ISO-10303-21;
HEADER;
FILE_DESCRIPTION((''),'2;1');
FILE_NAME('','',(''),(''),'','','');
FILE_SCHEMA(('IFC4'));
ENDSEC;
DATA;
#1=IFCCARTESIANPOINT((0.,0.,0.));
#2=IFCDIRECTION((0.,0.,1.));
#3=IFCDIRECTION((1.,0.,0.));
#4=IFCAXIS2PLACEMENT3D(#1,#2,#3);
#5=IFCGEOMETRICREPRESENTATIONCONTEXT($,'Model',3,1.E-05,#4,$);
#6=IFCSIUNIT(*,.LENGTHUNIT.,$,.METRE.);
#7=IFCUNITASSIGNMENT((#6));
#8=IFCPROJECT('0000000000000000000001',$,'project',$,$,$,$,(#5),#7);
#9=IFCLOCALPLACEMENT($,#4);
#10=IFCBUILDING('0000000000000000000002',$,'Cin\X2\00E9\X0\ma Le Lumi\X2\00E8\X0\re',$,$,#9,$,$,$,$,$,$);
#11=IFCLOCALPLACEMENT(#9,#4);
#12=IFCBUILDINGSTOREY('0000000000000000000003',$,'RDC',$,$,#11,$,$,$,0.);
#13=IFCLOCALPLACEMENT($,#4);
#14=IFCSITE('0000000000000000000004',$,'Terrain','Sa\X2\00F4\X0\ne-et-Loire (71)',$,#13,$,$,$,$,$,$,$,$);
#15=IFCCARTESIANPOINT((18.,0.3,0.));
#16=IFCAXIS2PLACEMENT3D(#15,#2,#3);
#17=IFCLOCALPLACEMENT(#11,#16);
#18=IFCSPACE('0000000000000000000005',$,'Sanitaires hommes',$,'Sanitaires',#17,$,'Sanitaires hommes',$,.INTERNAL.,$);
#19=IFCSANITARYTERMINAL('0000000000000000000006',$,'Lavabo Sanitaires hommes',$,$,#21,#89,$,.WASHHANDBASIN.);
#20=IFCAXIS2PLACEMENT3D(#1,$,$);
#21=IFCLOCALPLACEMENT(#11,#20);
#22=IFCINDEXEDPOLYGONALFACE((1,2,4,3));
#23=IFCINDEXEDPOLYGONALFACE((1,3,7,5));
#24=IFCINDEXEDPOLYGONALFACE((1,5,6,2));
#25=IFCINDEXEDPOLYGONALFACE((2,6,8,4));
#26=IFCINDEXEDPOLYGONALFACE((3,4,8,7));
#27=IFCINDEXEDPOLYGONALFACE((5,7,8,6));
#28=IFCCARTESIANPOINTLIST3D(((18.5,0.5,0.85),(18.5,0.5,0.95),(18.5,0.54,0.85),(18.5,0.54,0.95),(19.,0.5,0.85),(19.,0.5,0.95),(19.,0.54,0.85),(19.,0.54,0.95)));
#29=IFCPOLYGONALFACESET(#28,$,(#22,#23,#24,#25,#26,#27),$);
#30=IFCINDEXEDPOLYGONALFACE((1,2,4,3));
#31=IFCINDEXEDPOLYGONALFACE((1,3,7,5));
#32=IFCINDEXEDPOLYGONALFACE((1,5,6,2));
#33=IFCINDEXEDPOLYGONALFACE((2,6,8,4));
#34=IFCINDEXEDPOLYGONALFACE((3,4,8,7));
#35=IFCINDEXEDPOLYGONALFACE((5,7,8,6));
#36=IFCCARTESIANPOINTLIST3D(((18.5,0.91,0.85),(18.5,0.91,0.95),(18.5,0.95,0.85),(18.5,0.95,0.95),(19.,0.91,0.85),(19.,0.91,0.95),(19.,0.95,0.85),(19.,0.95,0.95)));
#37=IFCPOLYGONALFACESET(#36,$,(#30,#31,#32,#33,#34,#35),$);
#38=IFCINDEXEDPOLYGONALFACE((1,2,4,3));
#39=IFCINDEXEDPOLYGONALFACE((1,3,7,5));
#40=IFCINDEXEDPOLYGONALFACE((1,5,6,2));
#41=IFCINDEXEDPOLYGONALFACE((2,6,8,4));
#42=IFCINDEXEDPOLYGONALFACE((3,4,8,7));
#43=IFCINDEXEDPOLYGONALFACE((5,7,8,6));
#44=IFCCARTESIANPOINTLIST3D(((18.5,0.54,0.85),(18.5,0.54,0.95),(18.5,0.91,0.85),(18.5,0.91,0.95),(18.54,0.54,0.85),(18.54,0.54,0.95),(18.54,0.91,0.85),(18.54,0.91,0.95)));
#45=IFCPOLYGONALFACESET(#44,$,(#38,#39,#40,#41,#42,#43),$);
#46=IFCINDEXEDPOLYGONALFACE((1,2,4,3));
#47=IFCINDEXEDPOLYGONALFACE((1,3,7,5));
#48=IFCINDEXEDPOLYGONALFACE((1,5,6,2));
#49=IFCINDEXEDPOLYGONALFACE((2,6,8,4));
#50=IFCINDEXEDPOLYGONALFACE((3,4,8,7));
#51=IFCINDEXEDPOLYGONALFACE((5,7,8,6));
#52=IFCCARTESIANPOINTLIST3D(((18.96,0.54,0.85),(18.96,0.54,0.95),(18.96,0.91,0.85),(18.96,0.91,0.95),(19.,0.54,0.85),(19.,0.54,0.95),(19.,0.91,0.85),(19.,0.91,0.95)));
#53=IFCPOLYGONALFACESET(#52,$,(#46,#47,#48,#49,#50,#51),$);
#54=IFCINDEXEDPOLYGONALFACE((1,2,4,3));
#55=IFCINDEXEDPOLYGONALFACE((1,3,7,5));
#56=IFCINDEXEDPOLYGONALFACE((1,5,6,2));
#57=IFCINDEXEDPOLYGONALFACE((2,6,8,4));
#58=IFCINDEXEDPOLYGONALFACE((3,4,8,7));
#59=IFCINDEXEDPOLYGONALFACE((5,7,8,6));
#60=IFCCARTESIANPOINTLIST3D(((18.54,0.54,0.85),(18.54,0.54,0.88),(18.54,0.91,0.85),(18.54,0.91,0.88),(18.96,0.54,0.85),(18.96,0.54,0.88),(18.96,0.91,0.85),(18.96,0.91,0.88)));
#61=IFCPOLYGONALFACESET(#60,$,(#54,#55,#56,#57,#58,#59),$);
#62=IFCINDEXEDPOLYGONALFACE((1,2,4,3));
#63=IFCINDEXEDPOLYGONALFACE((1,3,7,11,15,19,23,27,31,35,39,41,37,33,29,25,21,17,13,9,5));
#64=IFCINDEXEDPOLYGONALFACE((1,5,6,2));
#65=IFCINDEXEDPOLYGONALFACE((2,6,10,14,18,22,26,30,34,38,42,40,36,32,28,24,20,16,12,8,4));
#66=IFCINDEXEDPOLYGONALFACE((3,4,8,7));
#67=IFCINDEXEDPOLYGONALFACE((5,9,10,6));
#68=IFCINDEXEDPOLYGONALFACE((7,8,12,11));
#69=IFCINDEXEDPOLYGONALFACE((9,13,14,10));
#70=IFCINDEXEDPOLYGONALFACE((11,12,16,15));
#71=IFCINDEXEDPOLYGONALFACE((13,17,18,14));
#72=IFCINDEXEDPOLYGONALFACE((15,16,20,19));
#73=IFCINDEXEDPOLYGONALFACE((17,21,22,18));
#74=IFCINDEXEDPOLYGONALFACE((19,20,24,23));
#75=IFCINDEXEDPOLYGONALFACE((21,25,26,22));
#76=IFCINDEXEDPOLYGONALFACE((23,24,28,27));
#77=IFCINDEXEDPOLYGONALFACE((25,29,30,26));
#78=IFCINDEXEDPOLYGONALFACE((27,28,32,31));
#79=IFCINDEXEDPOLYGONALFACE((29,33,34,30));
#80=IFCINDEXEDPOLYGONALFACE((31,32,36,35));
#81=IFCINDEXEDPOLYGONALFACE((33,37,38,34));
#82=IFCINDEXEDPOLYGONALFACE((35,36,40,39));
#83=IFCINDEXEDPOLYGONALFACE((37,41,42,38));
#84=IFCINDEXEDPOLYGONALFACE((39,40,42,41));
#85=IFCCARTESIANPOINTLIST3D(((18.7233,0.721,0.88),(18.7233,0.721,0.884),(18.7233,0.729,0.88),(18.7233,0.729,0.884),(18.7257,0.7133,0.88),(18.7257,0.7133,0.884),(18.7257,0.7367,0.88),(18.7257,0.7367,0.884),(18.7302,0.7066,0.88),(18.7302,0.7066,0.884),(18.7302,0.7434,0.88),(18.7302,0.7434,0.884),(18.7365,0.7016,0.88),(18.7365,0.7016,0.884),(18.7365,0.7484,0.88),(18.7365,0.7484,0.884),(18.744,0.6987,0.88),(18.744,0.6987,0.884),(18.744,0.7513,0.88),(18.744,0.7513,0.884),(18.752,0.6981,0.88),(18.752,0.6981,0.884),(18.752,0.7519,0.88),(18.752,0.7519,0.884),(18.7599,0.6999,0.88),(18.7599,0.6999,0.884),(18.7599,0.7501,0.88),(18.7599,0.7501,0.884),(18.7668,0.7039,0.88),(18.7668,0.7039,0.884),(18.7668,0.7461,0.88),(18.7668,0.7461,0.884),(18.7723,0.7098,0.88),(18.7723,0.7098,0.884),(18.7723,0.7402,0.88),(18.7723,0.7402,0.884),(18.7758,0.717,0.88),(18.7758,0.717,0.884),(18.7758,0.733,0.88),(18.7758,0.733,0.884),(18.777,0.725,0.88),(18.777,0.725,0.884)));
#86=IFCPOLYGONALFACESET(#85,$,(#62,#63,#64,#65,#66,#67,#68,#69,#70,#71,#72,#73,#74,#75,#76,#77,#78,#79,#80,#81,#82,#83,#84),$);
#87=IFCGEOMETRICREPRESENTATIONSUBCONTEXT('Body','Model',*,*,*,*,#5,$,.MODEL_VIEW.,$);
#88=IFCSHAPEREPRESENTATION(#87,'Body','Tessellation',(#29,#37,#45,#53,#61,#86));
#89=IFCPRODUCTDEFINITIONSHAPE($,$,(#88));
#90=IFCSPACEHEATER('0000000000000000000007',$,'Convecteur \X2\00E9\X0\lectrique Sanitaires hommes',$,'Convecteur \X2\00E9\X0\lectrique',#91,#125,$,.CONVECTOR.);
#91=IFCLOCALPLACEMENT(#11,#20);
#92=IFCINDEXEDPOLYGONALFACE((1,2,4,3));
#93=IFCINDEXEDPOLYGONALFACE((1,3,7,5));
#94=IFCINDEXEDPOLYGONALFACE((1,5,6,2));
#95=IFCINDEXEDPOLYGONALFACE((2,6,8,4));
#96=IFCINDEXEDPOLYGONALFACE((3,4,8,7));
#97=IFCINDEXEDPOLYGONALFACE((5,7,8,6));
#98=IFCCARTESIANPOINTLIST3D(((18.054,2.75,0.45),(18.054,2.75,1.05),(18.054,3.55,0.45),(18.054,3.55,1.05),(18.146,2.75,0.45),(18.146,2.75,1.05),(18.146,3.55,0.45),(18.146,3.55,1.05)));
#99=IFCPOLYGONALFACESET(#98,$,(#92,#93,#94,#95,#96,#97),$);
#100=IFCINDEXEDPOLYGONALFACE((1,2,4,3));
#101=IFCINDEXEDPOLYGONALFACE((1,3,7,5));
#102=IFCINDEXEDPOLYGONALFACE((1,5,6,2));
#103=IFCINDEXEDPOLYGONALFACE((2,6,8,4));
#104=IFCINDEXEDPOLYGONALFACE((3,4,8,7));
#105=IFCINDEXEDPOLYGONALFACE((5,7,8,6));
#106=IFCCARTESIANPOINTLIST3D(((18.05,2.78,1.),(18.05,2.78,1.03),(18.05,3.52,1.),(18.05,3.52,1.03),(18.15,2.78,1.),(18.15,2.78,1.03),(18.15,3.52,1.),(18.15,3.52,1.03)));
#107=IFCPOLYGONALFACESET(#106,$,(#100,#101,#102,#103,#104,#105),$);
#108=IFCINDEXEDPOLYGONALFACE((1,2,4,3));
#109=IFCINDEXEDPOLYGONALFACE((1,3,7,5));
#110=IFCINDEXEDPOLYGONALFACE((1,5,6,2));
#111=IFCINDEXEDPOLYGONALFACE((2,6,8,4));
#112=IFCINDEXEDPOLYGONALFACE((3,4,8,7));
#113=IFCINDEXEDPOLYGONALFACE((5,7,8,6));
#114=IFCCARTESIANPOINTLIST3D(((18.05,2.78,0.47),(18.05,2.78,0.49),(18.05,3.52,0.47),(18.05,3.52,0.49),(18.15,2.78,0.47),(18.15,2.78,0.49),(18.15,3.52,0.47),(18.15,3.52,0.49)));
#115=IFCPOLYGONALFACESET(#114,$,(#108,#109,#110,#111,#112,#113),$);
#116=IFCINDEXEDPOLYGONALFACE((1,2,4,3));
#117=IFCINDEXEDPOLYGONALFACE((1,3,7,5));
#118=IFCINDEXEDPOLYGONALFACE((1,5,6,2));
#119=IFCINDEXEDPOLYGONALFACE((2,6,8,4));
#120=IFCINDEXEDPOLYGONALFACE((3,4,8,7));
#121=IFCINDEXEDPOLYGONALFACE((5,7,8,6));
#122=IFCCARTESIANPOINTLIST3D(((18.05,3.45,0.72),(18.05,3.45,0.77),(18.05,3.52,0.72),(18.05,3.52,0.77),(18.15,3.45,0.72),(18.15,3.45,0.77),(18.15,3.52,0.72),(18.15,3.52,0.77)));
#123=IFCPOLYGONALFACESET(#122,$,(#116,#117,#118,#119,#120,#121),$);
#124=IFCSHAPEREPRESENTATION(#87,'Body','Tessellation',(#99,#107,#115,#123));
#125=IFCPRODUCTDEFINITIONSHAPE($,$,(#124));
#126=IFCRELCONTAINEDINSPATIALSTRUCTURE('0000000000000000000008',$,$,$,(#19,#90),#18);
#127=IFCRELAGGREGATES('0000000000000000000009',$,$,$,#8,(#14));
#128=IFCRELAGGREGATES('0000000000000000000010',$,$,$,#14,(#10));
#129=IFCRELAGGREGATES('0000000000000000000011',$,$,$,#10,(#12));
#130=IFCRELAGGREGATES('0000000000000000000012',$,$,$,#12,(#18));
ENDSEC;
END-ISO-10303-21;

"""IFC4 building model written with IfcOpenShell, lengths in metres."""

from ifc_helpers import new_model, si_unit, frame, frame_2d, origin_with_axes, place, context, subcontext, project, spatial, rectangle, circle, extrude, element, save


model = new_model("IFC4")

# Units and contexts
model_context = context("Model", 3, precision=1e-05, world=origin_with_axes())
body_context = subcontext(model_context, "Body", "Model", "MODEL_VIEW")
ifc_project = project(units=[si_unit("LENGTHUNIT", "METRE")], contexts=[model_context])

# Site, building, storey
site_placement = place(None, origin_with_axes())
site = spatial("IfcSite", under=ifc_project, at=site_placement, Name="Terrain", Description="Saône-et-Loire (71)")
building_placement = place(None, origin_with_axes())
building = spatial("IfcBuilding", under=site, at=building_placement, Name="Cinéma Le Lumière")
storey_placement = place(building_placement, origin_with_axes())
storey = spatial("IfcBuildingStorey", under=building, at=storey_placement, Name="RDC", Elevation=0.0)

# Shared definitions
space_1_placement = place(storey_placement, frame((18.0, 0.3, 0.0), z_axis=(0.0, 0.0, 1.0), x_axis=(1.0, 0.0, 0.0)))
space_1 = spatial("IfcSpace", under=storey, at=space_1_placement, Name="Sanitaires hommes", ObjectType="Sanitaires", LongName="Sanitaires hommes", PredefinedType="INTERNAL")

# Sanitary terminal
sanitary_terminal_1_placement = place(space_1_placement, frame((0.5, 0.2, 0.85), z_axis=(0.0, 0.0, 1.0), x_axis=(1.0, 0.0, 0.0)))
element("IfcSanitaryTerminal", 1, at=sanitary_terminal_1_placement, inside=space_1, Name="Lavabo Sanitaires hommes", PredefinedType="WASHHANDBASIN", context=body_context, shape_type="SweptSolid", body=[
    extrude(rectangle(XDim=0.5, YDim=0.04, at=frame_2d((0.25, 0.02))), origin_with_axes(), (0.0, 0.0, 1.0), 0.1),
    extrude(rectangle(XDim=0.5, YDim=0.04, at=frame_2d((0.25, 0.02))), frame((0.0, 0.41, 0.0), z_axis=(0.0, 0.0, 1.0), x_axis=(1.0, 0.0, 0.0)), (0.0, 0.0, 1.0), 0.1),
    extrude(rectangle(XDim=0.04, YDim=0.37, at=frame_2d((0.02, 0.185))), frame((0.0, 0.04, 0.0), z_axis=(0.0, 0.0, 1.0), x_axis=(1.0, 0.0, 0.0)), (0.0, 0.0, 1.0), 0.1),
    extrude(rectangle(XDim=0.04, YDim=0.37, at=frame_2d((0.02, 0.185))), frame((0.46, 0.04, 0.0), z_axis=(0.0, 0.0, 1.0), x_axis=(1.0, 0.0, 0.0)), (0.0, 0.0, 1.0), 0.1),
    extrude(rectangle(XDim=0.42, YDim=0.37, at=frame_2d((0.21, 0.185))), frame((0.04, 0.04, 0.0), z_axis=(0.0, 0.0, 1.0), x_axis=(1.0, 0.0, 0.0)), (0.0, 0.0, 1.0), 0.03),
    extrude(circle(Radius=0.027), frame((0.25, 0.225, 0.03), z_axis=(0.0, 0.0, 1.0), x_axis=(1.0, 0.0, 0.0)), (0.0, 0.0, 1.0), 0.004),
])

# Space heater
space_heater_placement = place(space_1_placement, frame((0.05, 2.45, 0.45), z_axis=(0.0, 0.0, 1.0), x_axis=(1.0, 0.0, 0.0)))
element("IfcSpaceHeater", 2, at=space_heater_placement, inside=space_1, Name="Convecteur électrique Sanitaires hommes", ObjectType="Convecteur électrique", PredefinedType="CONVECTOR", context=body_context, shape_type="SweptSolid", body=[
    extrude(rectangle(XDim=0.092, YDim=0.8, at=frame_2d((0.046, 0.4))), frame((0.004, 0.0, 0.0), z_axis=(0.0, 0.0, 1.0), x_axis=(1.0, 0.0, 0.0)), (0.0, 0.0, 1.0), 0.6),
    extrude(rectangle(XDim=0.1, YDim=0.74, at=frame_2d((0.05, 0.37))), frame((0.0, 0.03, 0.55), z_axis=(0.0, 0.0, 1.0), x_axis=(1.0, 0.0, 0.0)), (0.0, 0.0, 1.0), 0.03),
    extrude(rectangle(XDim=0.1, YDim=0.74, at=frame_2d((0.05, 0.37))), frame((0.0, 0.03, 0.02), z_axis=(0.0, 0.0, 1.0), x_axis=(1.0, 0.0, 0.0)), (0.0, 0.0, 1.0), 0.02),
    extrude(rectangle(XDim=0.1, YDim=0.07, at=frame_2d((0.05, 0.035))), frame((0.0, 0.7, 0.27), z_axis=(0.0, 0.0, 1.0), x_axis=(1.0, 0.0, 0.0)), (0.0, 0.0, 1.0), 0.05),
])

save(model, "model.ifc")
